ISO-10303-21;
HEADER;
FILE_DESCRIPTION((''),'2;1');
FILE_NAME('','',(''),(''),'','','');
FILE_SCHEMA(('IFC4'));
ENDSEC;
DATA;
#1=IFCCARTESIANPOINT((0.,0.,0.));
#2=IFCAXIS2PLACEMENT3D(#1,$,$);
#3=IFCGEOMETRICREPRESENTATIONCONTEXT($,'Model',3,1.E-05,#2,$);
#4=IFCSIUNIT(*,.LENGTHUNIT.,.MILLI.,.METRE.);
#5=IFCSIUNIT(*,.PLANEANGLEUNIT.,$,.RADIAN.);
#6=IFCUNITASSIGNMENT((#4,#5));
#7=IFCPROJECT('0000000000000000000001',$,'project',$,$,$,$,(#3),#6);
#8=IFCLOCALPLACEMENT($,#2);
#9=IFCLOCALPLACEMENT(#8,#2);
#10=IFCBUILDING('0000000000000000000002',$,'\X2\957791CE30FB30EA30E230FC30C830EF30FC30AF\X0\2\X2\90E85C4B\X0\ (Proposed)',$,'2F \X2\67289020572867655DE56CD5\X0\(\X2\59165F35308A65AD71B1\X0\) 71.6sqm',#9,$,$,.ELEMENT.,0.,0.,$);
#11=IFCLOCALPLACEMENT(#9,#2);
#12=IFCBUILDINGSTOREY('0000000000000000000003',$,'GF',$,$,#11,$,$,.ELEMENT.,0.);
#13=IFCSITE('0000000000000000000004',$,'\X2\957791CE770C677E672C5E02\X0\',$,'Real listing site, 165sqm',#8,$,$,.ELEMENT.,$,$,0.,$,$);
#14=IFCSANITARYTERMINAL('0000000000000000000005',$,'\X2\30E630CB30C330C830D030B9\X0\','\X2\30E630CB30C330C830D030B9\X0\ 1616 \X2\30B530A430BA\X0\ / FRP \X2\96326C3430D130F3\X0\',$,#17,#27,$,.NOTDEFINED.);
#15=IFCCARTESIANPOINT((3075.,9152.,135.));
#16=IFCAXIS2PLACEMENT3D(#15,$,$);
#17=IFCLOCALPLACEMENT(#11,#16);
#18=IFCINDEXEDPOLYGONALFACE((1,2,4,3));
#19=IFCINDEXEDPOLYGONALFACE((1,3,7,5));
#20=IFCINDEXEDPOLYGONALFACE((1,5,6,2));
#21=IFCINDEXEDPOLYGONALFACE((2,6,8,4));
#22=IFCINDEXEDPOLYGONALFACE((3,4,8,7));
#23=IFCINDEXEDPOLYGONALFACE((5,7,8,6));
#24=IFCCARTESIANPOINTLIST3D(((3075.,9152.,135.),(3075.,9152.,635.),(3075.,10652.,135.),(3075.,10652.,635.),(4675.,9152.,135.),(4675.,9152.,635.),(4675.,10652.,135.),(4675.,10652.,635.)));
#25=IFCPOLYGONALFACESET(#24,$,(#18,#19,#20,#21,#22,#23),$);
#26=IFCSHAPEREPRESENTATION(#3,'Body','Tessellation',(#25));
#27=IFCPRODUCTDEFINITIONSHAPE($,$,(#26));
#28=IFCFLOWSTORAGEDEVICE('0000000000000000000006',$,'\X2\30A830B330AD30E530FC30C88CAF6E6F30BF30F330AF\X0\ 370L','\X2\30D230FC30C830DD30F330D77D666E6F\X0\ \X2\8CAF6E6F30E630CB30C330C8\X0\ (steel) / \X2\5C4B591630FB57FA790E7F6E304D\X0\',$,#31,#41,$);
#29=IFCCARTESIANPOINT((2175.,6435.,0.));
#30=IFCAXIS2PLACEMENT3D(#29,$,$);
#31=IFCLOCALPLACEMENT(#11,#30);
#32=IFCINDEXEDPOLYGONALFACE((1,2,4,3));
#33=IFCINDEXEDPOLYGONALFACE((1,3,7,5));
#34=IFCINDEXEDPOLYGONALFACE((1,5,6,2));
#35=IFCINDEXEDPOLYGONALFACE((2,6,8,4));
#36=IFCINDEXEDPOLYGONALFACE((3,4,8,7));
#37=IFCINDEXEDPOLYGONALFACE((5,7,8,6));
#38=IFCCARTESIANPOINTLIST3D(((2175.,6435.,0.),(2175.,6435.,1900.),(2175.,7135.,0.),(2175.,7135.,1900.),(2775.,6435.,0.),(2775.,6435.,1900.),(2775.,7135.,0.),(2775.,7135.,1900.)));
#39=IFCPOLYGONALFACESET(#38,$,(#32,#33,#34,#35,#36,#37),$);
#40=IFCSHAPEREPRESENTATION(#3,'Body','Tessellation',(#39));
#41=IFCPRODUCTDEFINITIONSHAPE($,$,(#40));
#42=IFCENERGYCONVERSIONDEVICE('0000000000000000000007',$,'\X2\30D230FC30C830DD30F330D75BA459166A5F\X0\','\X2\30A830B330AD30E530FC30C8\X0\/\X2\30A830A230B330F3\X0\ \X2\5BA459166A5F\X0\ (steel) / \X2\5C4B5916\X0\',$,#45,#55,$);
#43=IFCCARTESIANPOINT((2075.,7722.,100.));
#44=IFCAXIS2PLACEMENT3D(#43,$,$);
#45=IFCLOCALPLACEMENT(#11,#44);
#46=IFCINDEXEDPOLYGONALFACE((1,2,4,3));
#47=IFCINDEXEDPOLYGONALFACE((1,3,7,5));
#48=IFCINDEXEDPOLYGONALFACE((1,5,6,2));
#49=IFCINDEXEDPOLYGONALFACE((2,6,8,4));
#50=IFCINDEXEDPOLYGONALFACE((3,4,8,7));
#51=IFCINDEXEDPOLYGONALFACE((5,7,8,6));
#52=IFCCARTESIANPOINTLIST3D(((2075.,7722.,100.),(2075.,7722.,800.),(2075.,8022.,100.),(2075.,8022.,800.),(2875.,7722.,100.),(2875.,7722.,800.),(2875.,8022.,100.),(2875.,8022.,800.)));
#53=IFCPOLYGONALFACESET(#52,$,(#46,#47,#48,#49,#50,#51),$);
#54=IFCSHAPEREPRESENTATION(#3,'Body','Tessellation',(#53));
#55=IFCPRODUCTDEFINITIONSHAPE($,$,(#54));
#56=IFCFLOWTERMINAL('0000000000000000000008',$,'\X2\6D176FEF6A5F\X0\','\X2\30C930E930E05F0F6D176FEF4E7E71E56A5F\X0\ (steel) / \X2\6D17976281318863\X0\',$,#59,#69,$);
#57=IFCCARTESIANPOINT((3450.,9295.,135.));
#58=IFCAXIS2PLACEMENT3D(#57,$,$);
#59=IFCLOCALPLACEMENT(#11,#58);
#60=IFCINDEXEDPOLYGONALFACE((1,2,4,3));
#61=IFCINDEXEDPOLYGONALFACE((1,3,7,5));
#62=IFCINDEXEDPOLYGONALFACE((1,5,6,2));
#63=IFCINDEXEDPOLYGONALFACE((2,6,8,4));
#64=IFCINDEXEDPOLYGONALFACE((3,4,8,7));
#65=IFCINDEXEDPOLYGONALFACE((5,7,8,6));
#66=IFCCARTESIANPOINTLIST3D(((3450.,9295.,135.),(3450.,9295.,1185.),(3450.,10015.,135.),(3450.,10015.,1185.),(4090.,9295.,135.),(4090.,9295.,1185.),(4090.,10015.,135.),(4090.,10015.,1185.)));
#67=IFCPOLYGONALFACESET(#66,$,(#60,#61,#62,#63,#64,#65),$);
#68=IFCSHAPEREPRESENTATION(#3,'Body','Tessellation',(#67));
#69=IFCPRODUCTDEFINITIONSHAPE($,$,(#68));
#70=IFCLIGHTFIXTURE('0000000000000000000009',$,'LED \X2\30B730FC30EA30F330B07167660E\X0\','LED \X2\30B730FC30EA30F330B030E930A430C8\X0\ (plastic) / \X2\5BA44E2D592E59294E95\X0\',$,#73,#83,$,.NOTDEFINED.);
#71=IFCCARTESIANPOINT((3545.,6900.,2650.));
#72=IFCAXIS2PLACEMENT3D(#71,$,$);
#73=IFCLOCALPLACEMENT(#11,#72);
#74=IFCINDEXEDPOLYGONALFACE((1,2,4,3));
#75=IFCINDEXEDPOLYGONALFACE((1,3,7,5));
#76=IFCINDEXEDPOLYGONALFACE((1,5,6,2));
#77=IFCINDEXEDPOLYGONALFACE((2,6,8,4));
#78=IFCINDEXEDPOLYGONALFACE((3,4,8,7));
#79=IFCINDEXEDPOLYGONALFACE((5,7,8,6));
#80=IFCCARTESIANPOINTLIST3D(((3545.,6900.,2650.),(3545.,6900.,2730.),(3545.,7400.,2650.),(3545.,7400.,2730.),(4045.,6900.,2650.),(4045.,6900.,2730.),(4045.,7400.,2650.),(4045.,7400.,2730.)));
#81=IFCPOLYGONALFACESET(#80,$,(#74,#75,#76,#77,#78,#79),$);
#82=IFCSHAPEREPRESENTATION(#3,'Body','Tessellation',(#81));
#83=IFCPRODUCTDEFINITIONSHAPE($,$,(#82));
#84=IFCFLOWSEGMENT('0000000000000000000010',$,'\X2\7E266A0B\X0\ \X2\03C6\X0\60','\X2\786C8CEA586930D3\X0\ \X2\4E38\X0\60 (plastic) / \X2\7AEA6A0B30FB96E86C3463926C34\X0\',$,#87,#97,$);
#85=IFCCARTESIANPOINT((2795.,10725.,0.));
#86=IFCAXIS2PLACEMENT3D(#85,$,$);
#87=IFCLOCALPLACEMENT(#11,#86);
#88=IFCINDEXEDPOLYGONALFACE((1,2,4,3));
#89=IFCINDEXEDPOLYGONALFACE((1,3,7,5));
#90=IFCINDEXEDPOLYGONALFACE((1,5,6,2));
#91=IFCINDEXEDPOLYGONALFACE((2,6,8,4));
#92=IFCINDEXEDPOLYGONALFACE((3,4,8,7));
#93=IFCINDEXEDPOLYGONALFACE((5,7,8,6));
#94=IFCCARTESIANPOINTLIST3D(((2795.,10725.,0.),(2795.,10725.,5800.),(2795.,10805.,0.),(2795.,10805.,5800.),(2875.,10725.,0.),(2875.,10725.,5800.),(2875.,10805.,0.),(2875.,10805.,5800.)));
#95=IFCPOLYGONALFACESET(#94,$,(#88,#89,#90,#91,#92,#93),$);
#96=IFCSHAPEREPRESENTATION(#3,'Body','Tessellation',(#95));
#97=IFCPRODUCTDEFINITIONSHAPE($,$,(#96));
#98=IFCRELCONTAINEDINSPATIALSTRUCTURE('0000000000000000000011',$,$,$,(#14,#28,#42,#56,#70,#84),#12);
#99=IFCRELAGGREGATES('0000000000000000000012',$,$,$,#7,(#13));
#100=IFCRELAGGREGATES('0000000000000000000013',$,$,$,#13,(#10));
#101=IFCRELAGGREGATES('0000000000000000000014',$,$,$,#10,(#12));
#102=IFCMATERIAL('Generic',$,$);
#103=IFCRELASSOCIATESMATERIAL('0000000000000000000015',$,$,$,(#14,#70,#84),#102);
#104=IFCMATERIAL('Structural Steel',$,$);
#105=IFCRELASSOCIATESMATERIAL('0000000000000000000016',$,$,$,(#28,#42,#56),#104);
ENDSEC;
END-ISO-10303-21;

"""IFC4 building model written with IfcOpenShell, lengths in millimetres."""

from ifc_helpers import new_model, si_unit, frame, frame_2d, origin, place, context, project, spatial, rectangle, extrude, material, element, save


model = new_model("IFC4")

# Units and contexts
model_context = context("Model", 3, precision=1e-05, world=origin())
ifc_project = project(units=[si_unit("LENGTHUNIT", "METRE", prefix="MILLI"), si_unit("PLANEANGLEUNIT", "RADIAN")], contexts=[model_context])

# Site, building, storey
site_placement = place(None, origin())
site = spatial("IfcSite", under=ifc_project, at=site_placement, Name="長野県松本市", ObjectType="Real listing site, 165sqm", CompositionType="ELEMENT", RefElevation=0.0)
building_placement = place(site_placement, origin())
building = spatial("IfcBuilding", under=site, at=building_placement, Name="長野・リモートワーク2部屋 (Proposed)", ObjectType="2F 木造在来工法(外張り断熱) 71.6sqm", CompositionType="ELEMENT", ElevationOfRefHeight=0.0, ElevationOfTerrain=0.0)
storey_placement = place(building_placement, origin())
storey = spatial("IfcBuildingStorey", under=building, at=storey_placement, Name="GF", CompositionType="ELEMENT", Elevation=0.0)

# Shared definitions
ifc_material_1 = material(Name="Generic")

# Sanitary terminal
sanitary_terminal_placement = place(storey_placement, frame((3075.0, 9152.0, 135.0)))
element("IfcSanitaryTerminal", 1, at=sanitary_terminal_placement, inside=storey, material=ifc_material_1, Name="ユニットバス", Description="ユニットバス 1616 サイズ / FRP 防水パン", PredefinedType="NOTDEFINED", context=model_context, shape_type="SweptSolid", body=[
    extrude(rectangle(XDim=1600.0, YDim=1500.0, at=frame_2d((800.0, 750.0))), frame((3075.0, 9152.0, 135.0)), (0.0, 0.0, 1.0), 500.0),
])

# Flow storage device
ifc_material_2 = material(Name="Structural Steel")
flow_storage_device_placement = place(storey_placement, frame((2175.0, 6435.0, 0.0)))
element("IfcFlowStorageDevice", 2, at=flow_storage_device_placement, inside=storey, material=ifc_material_2, Name="エコキュート貯湯タンク 370L", Description="ヒートポンプ給湯 貯湯ユニット (steel) / 屋外・基礎置き", context=model_context, shape_type="SweptSolid", body=[
    extrude(rectangle(XDim=600.0, YDim=700.0, at=frame_2d((300.0, 350.0))), frame((2175.0, 6435.0, 0.0)), (0.0, 0.0, 1.0), 1900.0),
])

# Energy conversion device
energy_conversion_device_placement = place(storey_placement, frame((2075.0, 7722.0, 100.0)))
element("IfcEnergyConversionDevice", 3, at=energy_conversion_device_placement, inside=storey, material=ifc_material_2, Name="ヒートポンプ室外機", Description="エコキュート/エアコン 室外機 (steel) / 屋外", context=model_context, shape_type="SweptSolid", body=[
    extrude(rectangle(XDim=800.0, YDim=300.0, at=frame_2d((400.0, 150.0))), frame((2075.0, 7722.0, 100.0)), (0.0, 0.0, 1.0), 700.0),
])

# Flow terminal
flow_terminal_placement = place(storey_placement, frame((3450.0, 9295.0, 135.0)))
element("IfcFlowTerminal", 4, at=flow_terminal_placement, inside=storey, material=ifc_material_2, Name="洗濯機", Description="ドラム式洗濯乾燥機 (steel) / 洗面脱衣", context=model_context, shape_type="SweptSolid", body=[
    extrude(rectangle(XDim=640.0, YDim=720.0, at=frame_2d((320.0, 360.0))), frame((3450.0, 9295.0, 135.0)), (0.0, 0.0, 1.0), 1050.0),
])

# Light fixture
light_fixture_placement = place(storey_placement, frame((3545.0, 6900.0, 2650.0)))
element("IfcLightFixture", 5, at=light_fixture_placement, inside=storey, material=ifc_material_1, Name="LED シーリング照明", Description="LED シーリングライト (plastic) / 室中央天井", PredefinedType="NOTDEFINED", context=model_context, shape_type="SweptSolid", body=[
    extrude(rectangle(XDim=500.0, YDim=500.0, at=frame_2d((250.0, 250.0))), frame((3545.0, 6900.0, 2650.0)), (0.0, 0.0, 1.0), 80.0),
])

# Flow segment
flow_segment_placement = place(storey_placement, frame((2795.0, 10725.0, 0.0)))
element("IfcFlowSegment", 6, at=flow_segment_placement, inside=storey, material=ifc_material_1, Name="縦樋 φ60", Description="硬質塩ビ 丸60 (plastic) / 竪樋・雨水排水", context=model_context, shape_type="SweptSolid", body=[
    extrude(rectangle(XDim=80.0, YDim=80.0, at=frame_2d((40.0, 40.0))), frame((2795.0, 10725.0, 0.0)), (0.0, 0.0, 1.0), 5800.0),
])

save(model, "model.ifc")
